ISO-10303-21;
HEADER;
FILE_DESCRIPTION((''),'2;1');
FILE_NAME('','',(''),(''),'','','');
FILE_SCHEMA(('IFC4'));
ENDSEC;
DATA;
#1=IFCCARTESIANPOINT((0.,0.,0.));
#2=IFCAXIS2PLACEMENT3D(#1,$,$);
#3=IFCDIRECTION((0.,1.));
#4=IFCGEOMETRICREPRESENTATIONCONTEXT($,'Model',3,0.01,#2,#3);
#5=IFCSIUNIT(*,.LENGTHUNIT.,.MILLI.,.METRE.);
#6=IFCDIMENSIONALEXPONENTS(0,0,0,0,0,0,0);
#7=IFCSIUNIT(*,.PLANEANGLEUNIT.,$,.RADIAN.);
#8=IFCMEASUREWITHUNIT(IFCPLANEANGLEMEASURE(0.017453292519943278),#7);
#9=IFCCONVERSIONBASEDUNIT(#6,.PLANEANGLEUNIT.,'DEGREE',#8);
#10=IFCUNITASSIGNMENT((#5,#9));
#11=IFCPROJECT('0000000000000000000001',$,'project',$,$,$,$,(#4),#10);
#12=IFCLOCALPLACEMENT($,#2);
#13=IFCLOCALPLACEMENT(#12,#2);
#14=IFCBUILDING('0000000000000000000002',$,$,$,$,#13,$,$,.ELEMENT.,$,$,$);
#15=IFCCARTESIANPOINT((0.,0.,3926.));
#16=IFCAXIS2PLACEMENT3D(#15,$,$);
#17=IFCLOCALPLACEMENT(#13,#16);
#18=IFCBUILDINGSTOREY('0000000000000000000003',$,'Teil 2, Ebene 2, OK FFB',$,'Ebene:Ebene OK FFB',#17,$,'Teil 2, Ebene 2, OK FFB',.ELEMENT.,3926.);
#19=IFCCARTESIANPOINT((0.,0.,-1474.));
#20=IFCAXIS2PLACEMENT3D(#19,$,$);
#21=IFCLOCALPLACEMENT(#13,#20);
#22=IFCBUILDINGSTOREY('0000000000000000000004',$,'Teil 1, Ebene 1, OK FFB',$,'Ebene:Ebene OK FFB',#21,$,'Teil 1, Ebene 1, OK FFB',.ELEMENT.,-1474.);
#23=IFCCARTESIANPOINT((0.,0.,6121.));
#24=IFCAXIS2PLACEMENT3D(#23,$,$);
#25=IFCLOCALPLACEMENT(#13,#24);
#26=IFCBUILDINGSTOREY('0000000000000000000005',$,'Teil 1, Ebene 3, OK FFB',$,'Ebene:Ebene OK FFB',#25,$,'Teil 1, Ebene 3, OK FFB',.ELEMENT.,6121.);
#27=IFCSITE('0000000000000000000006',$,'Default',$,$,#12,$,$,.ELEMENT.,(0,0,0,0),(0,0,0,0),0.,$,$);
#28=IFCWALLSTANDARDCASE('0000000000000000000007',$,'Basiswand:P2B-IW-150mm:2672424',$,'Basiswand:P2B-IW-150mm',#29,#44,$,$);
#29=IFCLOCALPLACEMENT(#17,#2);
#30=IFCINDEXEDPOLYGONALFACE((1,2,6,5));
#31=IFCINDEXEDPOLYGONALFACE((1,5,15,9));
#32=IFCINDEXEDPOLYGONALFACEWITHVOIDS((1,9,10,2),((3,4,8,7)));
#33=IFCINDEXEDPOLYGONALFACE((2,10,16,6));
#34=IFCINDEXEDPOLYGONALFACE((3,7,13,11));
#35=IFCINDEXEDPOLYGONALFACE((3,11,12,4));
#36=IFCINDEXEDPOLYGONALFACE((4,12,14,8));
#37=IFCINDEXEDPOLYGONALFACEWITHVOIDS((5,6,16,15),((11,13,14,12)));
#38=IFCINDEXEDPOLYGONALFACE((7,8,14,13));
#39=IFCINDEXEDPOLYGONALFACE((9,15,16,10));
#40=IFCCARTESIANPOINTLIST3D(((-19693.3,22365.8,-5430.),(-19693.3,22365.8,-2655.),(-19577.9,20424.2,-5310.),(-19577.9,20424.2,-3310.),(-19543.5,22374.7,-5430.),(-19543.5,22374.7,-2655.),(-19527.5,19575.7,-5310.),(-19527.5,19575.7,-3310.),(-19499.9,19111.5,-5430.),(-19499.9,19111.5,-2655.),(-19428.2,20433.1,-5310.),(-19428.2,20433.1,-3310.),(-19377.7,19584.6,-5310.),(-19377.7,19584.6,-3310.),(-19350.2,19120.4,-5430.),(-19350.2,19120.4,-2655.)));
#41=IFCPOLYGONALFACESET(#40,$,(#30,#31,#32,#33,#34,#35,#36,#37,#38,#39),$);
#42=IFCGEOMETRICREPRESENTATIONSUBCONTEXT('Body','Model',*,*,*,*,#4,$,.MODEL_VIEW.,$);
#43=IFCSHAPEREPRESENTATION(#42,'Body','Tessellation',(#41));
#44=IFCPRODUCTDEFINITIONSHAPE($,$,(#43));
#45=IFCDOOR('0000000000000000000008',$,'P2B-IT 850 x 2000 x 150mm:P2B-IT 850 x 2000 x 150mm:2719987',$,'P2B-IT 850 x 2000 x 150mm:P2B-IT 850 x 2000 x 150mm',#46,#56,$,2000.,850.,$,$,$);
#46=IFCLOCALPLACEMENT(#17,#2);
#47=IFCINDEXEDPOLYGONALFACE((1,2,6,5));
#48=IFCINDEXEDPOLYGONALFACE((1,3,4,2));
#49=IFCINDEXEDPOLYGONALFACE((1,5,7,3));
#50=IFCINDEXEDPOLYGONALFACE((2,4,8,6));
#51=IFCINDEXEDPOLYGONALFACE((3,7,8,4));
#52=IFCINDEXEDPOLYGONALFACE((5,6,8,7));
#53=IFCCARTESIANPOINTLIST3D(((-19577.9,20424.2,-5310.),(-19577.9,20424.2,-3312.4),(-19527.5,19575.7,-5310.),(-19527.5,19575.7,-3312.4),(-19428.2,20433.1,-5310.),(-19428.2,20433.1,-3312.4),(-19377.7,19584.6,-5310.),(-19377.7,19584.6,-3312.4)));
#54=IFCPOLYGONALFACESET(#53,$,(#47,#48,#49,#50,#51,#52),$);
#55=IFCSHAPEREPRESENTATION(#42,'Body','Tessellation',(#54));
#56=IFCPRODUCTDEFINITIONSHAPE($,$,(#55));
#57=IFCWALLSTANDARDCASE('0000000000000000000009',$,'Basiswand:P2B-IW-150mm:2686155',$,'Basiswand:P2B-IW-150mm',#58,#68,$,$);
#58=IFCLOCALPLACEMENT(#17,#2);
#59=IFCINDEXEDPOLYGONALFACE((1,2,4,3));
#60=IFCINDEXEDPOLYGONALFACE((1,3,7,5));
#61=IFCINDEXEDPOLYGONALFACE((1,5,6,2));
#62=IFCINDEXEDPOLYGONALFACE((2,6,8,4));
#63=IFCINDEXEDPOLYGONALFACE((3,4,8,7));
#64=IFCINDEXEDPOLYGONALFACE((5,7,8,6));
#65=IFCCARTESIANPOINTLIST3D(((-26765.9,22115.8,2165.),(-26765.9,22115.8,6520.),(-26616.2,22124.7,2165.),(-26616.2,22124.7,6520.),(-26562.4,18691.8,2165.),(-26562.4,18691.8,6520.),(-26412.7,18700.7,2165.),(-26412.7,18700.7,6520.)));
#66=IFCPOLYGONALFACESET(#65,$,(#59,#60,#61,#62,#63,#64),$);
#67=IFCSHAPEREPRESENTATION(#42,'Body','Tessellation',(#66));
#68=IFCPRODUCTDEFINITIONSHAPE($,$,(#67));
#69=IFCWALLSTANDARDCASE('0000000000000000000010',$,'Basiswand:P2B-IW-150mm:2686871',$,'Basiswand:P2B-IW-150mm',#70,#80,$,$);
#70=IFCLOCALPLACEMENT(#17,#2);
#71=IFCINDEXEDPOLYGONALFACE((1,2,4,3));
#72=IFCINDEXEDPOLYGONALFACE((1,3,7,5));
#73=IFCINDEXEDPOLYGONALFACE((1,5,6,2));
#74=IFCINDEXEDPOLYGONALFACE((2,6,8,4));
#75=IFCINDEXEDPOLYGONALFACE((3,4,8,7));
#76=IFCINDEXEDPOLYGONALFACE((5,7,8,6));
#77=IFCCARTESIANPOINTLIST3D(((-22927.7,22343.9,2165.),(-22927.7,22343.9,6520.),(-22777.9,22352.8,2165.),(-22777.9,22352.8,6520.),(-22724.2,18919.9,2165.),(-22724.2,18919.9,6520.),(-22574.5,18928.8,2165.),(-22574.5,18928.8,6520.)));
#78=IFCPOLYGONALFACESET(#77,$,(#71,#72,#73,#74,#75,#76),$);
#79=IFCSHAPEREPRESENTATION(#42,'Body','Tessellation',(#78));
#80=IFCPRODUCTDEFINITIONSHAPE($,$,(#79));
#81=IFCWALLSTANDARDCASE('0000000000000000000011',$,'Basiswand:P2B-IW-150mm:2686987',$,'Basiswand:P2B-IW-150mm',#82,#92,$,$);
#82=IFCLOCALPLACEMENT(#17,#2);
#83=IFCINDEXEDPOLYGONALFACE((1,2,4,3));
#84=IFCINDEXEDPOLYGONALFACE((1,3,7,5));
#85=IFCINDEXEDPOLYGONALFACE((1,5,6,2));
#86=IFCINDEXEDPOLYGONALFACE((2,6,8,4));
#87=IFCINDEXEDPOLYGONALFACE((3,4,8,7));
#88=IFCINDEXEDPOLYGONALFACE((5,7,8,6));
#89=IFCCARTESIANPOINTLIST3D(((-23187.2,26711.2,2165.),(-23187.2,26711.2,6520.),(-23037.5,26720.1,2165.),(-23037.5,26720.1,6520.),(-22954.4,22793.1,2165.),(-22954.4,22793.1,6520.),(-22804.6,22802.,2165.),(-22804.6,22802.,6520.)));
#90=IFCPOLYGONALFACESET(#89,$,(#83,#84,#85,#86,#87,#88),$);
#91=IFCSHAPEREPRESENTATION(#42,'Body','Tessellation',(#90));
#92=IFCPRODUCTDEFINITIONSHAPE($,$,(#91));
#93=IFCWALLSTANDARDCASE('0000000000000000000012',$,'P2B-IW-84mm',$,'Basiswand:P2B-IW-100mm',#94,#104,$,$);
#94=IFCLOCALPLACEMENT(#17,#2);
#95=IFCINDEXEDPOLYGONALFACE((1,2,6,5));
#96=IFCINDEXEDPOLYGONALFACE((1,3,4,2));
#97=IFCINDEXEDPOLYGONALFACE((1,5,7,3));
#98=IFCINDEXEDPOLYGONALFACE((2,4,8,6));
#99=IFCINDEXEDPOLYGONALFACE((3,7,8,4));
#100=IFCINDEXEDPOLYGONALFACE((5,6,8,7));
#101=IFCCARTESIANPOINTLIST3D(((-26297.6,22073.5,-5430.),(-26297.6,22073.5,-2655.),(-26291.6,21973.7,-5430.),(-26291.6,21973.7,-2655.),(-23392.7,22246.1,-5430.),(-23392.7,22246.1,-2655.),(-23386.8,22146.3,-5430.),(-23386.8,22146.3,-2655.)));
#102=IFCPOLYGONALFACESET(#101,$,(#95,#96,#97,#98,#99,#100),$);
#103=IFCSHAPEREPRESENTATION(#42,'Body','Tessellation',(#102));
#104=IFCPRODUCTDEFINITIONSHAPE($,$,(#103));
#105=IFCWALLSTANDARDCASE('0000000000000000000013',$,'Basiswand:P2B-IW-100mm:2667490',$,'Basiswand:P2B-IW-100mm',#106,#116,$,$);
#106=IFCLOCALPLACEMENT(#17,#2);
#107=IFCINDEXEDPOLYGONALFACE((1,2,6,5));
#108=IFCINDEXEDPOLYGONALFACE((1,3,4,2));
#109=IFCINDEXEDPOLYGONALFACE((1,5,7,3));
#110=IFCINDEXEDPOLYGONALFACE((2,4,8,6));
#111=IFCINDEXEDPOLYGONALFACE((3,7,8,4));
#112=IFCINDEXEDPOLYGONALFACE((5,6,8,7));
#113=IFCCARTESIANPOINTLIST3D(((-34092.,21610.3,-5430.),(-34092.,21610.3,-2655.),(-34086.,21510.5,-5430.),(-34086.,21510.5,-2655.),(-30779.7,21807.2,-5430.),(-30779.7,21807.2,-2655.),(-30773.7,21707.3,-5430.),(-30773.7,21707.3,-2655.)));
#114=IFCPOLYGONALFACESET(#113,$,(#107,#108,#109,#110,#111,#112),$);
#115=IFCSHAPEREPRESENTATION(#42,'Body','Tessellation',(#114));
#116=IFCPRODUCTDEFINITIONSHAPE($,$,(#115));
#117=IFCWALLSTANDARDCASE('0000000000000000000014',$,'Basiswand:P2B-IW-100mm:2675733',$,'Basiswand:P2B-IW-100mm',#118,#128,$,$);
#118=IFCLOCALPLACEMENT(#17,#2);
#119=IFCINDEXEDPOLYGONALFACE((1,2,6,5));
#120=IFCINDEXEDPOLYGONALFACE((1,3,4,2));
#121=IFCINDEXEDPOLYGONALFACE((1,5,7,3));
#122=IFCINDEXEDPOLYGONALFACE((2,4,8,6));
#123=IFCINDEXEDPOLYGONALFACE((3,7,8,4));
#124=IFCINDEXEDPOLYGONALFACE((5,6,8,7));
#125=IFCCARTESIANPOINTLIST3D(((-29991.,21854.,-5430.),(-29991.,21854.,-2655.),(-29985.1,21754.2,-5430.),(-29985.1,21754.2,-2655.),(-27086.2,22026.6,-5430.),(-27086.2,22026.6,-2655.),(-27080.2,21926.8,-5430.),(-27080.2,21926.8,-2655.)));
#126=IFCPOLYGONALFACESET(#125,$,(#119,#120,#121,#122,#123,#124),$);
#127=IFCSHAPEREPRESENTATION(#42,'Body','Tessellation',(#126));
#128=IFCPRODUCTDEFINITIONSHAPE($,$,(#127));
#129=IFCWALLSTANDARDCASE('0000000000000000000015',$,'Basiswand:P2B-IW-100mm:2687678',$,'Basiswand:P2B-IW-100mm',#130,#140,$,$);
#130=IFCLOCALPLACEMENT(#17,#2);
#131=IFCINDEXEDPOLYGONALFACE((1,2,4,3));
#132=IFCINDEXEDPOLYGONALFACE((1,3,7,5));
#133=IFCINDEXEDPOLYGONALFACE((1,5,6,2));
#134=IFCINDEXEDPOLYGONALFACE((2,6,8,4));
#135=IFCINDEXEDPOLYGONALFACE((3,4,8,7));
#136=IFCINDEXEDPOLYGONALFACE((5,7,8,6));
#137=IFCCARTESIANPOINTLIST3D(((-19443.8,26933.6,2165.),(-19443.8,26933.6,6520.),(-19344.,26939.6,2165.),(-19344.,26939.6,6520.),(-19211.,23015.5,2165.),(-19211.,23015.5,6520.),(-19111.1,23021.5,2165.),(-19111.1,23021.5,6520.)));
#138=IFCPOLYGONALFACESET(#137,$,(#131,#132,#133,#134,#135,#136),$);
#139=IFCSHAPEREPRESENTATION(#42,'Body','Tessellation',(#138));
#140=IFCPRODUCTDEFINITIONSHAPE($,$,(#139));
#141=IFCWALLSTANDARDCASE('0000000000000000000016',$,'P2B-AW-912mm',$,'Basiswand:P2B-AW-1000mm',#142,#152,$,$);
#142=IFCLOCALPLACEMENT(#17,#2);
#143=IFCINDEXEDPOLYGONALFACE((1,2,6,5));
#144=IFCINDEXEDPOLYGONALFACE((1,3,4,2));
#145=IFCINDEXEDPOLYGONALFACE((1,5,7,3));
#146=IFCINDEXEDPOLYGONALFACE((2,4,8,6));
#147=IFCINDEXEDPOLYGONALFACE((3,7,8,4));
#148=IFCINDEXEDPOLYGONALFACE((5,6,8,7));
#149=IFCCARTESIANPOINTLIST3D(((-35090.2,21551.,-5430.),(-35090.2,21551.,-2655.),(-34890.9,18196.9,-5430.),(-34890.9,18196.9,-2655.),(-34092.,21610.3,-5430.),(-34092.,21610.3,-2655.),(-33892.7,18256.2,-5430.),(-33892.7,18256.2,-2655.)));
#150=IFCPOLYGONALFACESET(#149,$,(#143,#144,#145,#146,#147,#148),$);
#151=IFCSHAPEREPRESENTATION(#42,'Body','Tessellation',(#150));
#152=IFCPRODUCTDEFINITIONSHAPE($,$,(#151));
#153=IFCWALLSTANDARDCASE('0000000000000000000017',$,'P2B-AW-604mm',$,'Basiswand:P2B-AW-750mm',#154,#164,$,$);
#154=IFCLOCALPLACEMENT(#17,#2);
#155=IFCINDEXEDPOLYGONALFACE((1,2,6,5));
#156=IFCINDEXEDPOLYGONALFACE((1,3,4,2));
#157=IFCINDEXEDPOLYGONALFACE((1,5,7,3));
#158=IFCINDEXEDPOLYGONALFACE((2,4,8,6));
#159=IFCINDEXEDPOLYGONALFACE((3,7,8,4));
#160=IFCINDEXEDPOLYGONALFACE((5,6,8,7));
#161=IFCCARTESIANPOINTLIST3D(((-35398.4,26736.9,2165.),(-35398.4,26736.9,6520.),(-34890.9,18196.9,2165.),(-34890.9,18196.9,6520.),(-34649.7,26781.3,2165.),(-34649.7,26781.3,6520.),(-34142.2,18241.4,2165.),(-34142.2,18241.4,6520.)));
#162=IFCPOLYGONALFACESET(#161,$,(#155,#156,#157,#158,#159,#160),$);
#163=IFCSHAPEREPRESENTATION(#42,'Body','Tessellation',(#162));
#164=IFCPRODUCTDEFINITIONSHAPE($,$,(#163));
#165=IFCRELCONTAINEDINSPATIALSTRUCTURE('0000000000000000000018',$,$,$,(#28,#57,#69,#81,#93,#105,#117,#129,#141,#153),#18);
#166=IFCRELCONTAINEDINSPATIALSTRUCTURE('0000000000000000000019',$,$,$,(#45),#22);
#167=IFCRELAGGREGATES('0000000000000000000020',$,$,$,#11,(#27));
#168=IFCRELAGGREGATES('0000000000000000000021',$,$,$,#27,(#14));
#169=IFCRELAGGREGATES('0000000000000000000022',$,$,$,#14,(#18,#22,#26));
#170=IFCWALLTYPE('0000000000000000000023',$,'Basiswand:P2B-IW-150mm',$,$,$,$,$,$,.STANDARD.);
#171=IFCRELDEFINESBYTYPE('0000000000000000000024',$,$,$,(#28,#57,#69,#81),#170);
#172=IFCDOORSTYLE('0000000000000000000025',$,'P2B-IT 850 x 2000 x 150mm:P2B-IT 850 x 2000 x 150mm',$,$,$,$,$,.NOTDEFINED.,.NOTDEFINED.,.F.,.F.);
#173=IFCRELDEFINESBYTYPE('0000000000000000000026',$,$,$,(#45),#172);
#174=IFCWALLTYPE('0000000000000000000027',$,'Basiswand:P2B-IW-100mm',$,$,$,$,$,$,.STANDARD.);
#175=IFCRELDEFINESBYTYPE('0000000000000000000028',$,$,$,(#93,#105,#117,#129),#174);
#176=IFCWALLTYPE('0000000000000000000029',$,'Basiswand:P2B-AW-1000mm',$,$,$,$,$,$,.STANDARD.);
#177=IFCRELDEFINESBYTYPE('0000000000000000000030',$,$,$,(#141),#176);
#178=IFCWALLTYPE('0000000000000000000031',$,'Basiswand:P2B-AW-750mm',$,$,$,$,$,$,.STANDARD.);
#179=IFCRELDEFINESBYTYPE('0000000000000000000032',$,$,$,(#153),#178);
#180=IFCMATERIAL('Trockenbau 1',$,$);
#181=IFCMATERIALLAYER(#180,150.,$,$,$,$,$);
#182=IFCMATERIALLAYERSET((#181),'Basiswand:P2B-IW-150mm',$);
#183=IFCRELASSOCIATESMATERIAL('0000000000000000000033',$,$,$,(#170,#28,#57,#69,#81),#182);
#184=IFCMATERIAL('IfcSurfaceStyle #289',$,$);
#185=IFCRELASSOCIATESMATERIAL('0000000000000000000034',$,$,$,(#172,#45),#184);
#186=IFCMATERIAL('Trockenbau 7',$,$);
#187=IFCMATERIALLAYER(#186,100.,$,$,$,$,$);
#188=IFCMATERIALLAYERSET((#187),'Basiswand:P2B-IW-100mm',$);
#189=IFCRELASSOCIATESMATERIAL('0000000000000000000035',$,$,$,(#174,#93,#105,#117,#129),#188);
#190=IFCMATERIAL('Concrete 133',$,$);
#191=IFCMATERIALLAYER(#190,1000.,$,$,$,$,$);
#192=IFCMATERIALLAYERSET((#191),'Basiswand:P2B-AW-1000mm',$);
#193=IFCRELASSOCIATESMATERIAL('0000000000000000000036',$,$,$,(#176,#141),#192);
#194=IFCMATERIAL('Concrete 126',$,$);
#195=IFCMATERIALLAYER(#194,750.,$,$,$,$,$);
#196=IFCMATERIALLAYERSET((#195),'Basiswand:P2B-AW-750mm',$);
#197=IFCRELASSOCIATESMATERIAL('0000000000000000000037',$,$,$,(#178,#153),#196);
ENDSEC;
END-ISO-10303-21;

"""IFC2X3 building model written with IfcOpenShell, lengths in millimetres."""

from ifc_helpers import new_model, entity, si_unit, converted_unit, direction, frame, frame_2d, origin, place, context, subcontext, project, spatial, rectangle, extrude, source, transform, mapped, material, layer, layer_set, layer_usage, type_object, type_shapes, element, fill, save


model = new_model("IFC2X3")

# Units and contexts
model_context = context("Model", 3, precision=0.01, world=origin(), true_north=direction((0.0, 1.0)))
body_context = subcontext(model_context, "Body", "Model", "MODEL_VIEW")
ifc_project = project(units=[si_unit("LENGTHUNIT", "METRE", prefix="MILLI"), converted_unit("PLANEANGLEUNIT", "DEGREE", entity("IfcPlaneAngleMeasure", 0.017453292519943278), si_unit("PLANEANGLEUNIT", "RADIAN"), dimensions=[0, 0, 0, 0, 0, 0, 0])], contexts=[model_context])

# Site, building, storey
site_placement = place(None, origin())
site = spatial("IfcSite", under=ifc_project, at=site_placement, Name="Default", CompositionType="ELEMENT", RefLatitude=(0, 0, 0, 0), RefLongitude=(0, 0, 0, 0), RefElevation=0.0)
building_placement = place(site_placement, origin())
building = spatial("IfcBuilding", under=site, at=building_placement, CompositionType="ELEMENT")
storey_1_placement = place(building_placement, frame((0.0, 0.0, 3926.0)))
storey_1 = spatial("IfcBuildingStorey", under=building, at=storey_1_placement, Name="Teil 2, Ebene 2, OK FFB", ObjectType="Ebene:Ebene OK FFB", LongName="Teil 2, Ebene 2, OK FFB", CompositionType="ELEMENT", Elevation=3926.0)

# Shared definitions
storey_2_placement = place(building_placement, frame((0.0, 0.0, -1474.0)))
storey_2 = spatial("IfcBuildingStorey", under=building, at=storey_2_placement, Name="Teil 1, Ebene 1, OK FFB", ObjectType="Ebene:Ebene OK FFB", LongName="Teil 1, Ebene 1, OK FFB", CompositionType="ELEMENT", Elevation=-1474.0)

# Shared definitions
ifc_material_1 = material(Name="IfcSurfaceStyle #289")

# Shared definitions
ifc_material_2 = material(Name="Trockenbau 1")
ifc_layer_1 = layer(ifc_material_2, 150.0)
ifc_layer_set_1 = layer_set([ifc_layer_1], Name="Basiswand:P2B-IW-150mm")
wall_type_1 = type_object("IfcWallType", Name="Basiswand:P2B-IW-150mm", PredefinedType="STANDARD", material=ifc_layer_set_1)

# Shared definitions
storey_3_placement = place(building_placement, frame((0.0, 0.0, 6121.0)))
storey_3 = spatial("IfcBuildingStorey", under=building, at=storey_3_placement, Name="Teil 1, Ebene 3, OK FFB", ObjectType="Ebene:Ebene OK FFB", LongName="Teil 1, Ebene 3, OK FFB", CompositionType="ELEMENT", Elevation=6121.0)

# Wall, opening, door
ifc_layer_usage_1 = layer_usage(ifc_layer_set_1, "AXIS2", "POSITIVE", -75.0)
wall_1_placement = place(storey_1_placement, frame((-19425.0, 19116.0, -5430.0), z_axis=(0.0, 0.0, 1.0), x_axis=(-0.059319, 0.998239, 0.0)))
wall_1 = element("IfcWallStandardCase", 1, at=wall_1_placement, inside=storey_1, type_object=wall_type_1, material=ifc_layer_usage_1, Name="Basiswand:P2B-IW-150mm:2672424", ObjectType="Basiswand:P2B-IW-150mm", context=body_context, shape_type="SweptSolid", body=[
    extrude(rectangle(XDim=3260.0, YDim=150.0, at=frame_2d((1630.0, 0.0), x_axis=(-1.0, 0.0))), origin(), (0.0, 0.0, 1.0), 2775.0),
])
opening_1_placement = place(wall_1_placement, frame((-20234.6, -18256.9, 30.0), z_axis=(0.0, 0.0, 1.0), x_axis=(-0.059319, -0.998239, 0.0)))
opening_1 = element("IfcOpeningElement", 2, at=opening_1_placement, cuts=wall_1, ObjectType="Opening", context=body_context, shape_type="SweptSolid", body=[
    extrude(rectangle(XDim=2000.0, YDim=850.0, at=frame_2d((0.0, 0.0), x_axis=(1.0, 0.0))), frame((-19402.9, 20008.9, 1090.0), z_axis=(-0.998239, -0.059319, 0.0), x_axis=(0.0, 0.0, -1.0)), (0.0, 0.0, 1.0), 150.0),
])
door_style_1 = type_object("IfcDoorStyle", Name="P2B-IT 850 x 2000 x 150mm:P2B-IT 850 x 2000 x 150mm", ConstructionType="NOTDEFINED", OperationType="NOTDEFINED", ParameterTakesPrecedence=False, Sizeable=False, material=ifc_material_1)
shared_shape_1 = source(origin(), body_context, "Body", "SweptSolid", [
    extrude(rectangle(XDim=150.0, YDim=850.0, at=frame_2d((0.0, 0.0), x_axis=(1.0, 0.0))), frame((425.0, -75.0, 0.0), z_axis=(0.0, 0.0, 1.0), x_axis=(0.0, 1.0, 0.0)), (0.0, 0.0, 1.0), 1997.6),
])
type_shapes(door_style_1, [shared_shape_1])
door_1_placement = place(opening_1_placement, frame((-19527.5, 19575.7, 90.0), z_axis=(0.0, 0.0, 1.0), x_axis=(-0.059319, 0.998239, 0.0)))
door_1 = element("IfcDoor", 3, at=door_1_placement, inside=storey_2, type_object=door_style_1, material=ifc_material_1, Name="P2B-IT 850 x 2000 x 150mm:P2B-IT 850 x 2000 x 150mm:2719987", ObjectType="P2B-IT 850 x 2000 x 150mm:P2B-IT 850 x 2000 x 150mm", OverallHeight=2000.0, OverallWidth=850.0, context=body_context, shape_type="MappedRepresentation", body=[
    mapped(shared_shape_1, transform((0.0, 0.0, 0.0), scale=1.0)),
])
fill(opening_1, door_1)

# Walls
ifc_layer_usage_2 = layer_usage(ifc_layer_set_1, "AXIS2", "NEGATIVE", 75.0)
wall_2_placement = place(storey_1_placement, frame((-26487.6, 18696.3, 2165.0), z_axis=(0.0, 0.0, 1.0), x_axis=(-0.059319, 0.998239, 0.0)))
element("IfcWallStandardCase", 4, at=wall_2_placement, inside=storey_1, type_object=wall_type_1, material=ifc_layer_usage_2, Name="Basiswand:P2B-IW-150mm:2686155", ObjectType="Basiswand:P2B-IW-150mm", context=body_context, shape_type="SweptSolid", body=[
    extrude(rectangle(XDim=3430.0, YDim=150.0, at=frame_2d((1715.0, 0.0), x_axis=(-1.0, 0.0))), origin(), (0.0, 0.0, 1.0), 4355.0),
])
ifc_layer_usage_3 = layer_usage(ifc_layer_set_1, "AXIS2", "NEGATIVE", 75.0)
wall_3_placement = place(storey_1_placement, frame((-22649.3, 18924.4, 2165.0), z_axis=(0.0, 0.0, 1.0), x_axis=(-0.059319, 0.998239, 0.0)))
element("IfcWallStandardCase", 5, at=wall_3_placement, inside=storey_1, type_object=wall_type_1, material=ifc_layer_usage_3, Name="Basiswand:P2B-IW-150mm:2686871", ObjectType="Basiswand:P2B-IW-150mm", context=body_context, shape_type="SweptSolid", body=[
    extrude(rectangle(XDim=3430.0, YDim=150.0, at=frame_2d((1715.0, 0.0), x_axis=(-1.0, 0.0))), origin(), (0.0, 0.0, 1.0), 4355.0),
])
ifc_layer_usage_4 = layer_usage(ifc_layer_set_1, "AXIS2", "NEGATIVE", 75.0)
wall_4_placement = place(storey_1_placement, frame((-22879.5, 22797.5, 2165.0), z_axis=(0.0, 0.0, 1.0), x_axis=(-0.059319, 0.998239, 0.0)))
element("IfcWallStandardCase", 6, at=wall_4_placement, inside=storey_1, type_object=wall_type_1, material=ifc_layer_usage_4, Name="Basiswand:P2B-IW-150mm:2686987", ObjectType="Basiswand:P2B-IW-150mm", context=body_context, shape_type="SweptSolid", body=[
    extrude(rectangle(XDim=3925.0, YDim=150.0, at=frame_2d((1962.5, 0.0), x_axis=(-1.0, 0.0))), origin(), (0.0, 0.0, 1.0), 4355.0),
])
ifc_material_3 = material(Name="Trockenbau 7")
ifc_layer_2 = layer(ifc_material_3, 100.0)
ifc_layer_set_2 = layer_set([ifc_layer_2], Name="Basiswand:P2B-IW-100mm")
ifc_layer_usage_5 = layer_usage(ifc_layer_set_2, "AXIS2", "POSITIVE", -50.0)
wall_type_2 = type_object("IfcWallType", Name="Basiswand:P2B-IW-100mm", PredefinedType="STANDARD", material=ifc_layer_set_2)
wall_5_placement = place(storey_1_placement, frame((-23389.7, 22196.2, -5430.0), z_axis=(0.0, 0.0, 1.0), x_axis=(-0.998239, -0.059319, 0.0)))
element("IfcWallStandardCase", 7, at=wall_5_placement, inside=storey_1, type_object=wall_type_2, material=ifc_layer_usage_5, Name="P2B-IW-84mm", ObjectType="Basiswand:P2B-IW-100mm", context=body_context, shape_type="SweptSolid", body=[
    extrude(rectangle(XDim=2910.0, YDim=100.0, at=frame_2d((1455.0, 0.0), x_axis=(-1.0, 0.0))), origin(), (0.0, 0.0, 1.0), 2775.0),
])
ifc_layer_usage_6 = layer_usage(ifc_layer_set_2, "AXIS2", "POSITIVE", -50.0)
wall_6_placement = place(storey_1_placement, frame((-30776.7, 21757.2, -5430.0), z_axis=(0.0, 0.0, 1.0), x_axis=(-0.998239, -0.059319, 0.0)))
element("IfcWallStandardCase", 8, at=wall_6_placement, inside=storey_1, type_object=wall_type_2, material=ifc_layer_usage_6, Name="Basiswand:P2B-IW-100mm:2667490", ObjectType="Basiswand:P2B-IW-100mm", context=body_context, shape_type="SweptSolid", body=[
    extrude(rectangle(XDim=3318.2, YDim=100.0, at=frame_2d((1659.1, 0.0), x_axis=(-1.0, 0.0))), origin(), (0.0, 0.0, 1.0), 2775.0),
])
ifc_layer_usage_7 = layer_usage(ifc_layer_set_2, "AXIS2", "POSITIVE", -50.0)
wall_7_placement = place(storey_1_placement, frame((-27083.2, 21976.7, -5430.0), z_axis=(0.0, 0.0, 1.0), x_axis=(-0.998239, -0.059319, 0.0)))
element("IfcWallStandardCase", 9, at=wall_7_placement, inside=storey_1, type_object=wall_type_2, material=ifc_layer_usage_7, Name="Basiswand:P2B-IW-100mm:2675733", ObjectType="Basiswand:P2B-IW-100mm", context=body_context, shape_type="SweptSolid", body=[
    extrude(rectangle(XDim=2910.0, YDim=100.0, at=frame_2d((1455.0, 0.0), x_axis=(-1.0, 0.0))), origin(), (0.0, 0.0, 1.0), 2775.0),
])

# Walls
ifc_layer_usage_8 = layer_usage(ifc_layer_set_2, "AXIS2", "NEGATIVE", 50.0)
wall_8_placement = place(storey_1_placement, frame((-19161.0, 23018.5, 2165.0), z_axis=(0.0, 0.0, 1.0), x_axis=(-0.059319, 0.998239, 0.0)))
element("IfcWallStandardCase", 10, at=wall_8_placement, inside=storey_1, type_object=wall_type_2, material=ifc_layer_usage_8, Name="Basiswand:P2B-IW-100mm:2687678", ObjectType="Basiswand:P2B-IW-100mm", context=body_context, shape_type="SweptSolid", body=[
    extrude(rectangle(XDim=3925.0, YDim=100.0, at=frame_2d((1962.5, 0.0), x_axis=(-1.0, 0.0))), origin(), (0.0, 0.0, 1.0), 4355.0),
])
ifc_material_4 = material(Name="Concrete 133")
ifc_layer_3 = layer(ifc_material_4, 1000.0)
ifc_layer_set_3 = layer_set([ifc_layer_3], Name="Basiswand:P2B-AW-1000mm")
ifc_layer_usage_9 = layer_usage(ifc_layer_set_3, "AXIS2", "NEGATIVE", 500.0)
wall_type_3 = type_object("IfcWallType", Name="Basiswand:P2B-AW-1000mm", PredefinedType="STANDARD", material=ifc_layer_set_3)
wall_9_placement = place(storey_1_placement, frame((-34391.8, 18226.6, -5430.0), z_axis=(0.0, 0.0, 1.0), x_axis=(-0.059319, 0.998239, 0.0)))
element("IfcWallStandardCase", 11, at=wall_9_placement, inside=storey_1, type_object=wall_type_3, material=ifc_layer_usage_9, Name="P2B-AW-912mm", ObjectType="Basiswand:P2B-AW-1000mm", context=body_context, shape_type="SweptSolid", body=[
    extrude(rectangle(XDim=3360.0, YDim=1000.0, at=frame_2d((1680.0, 0.0), x_axis=(-1.0, 0.0))), origin(), (0.0, 0.0, 1.0), 2775.0),
])
ifc_material_5 = material(Name="Concrete 126")
ifc_layer_4 = layer(ifc_material_5, 750.0)
ifc_layer_set_4 = layer_set([ifc_layer_4], Name="Basiswand:P2B-AW-750mm")
ifc_layer_usage_10 = layer_usage(ifc_layer_set_4, "AXIS2", "NEGATIVE", 375.0)
wall_type_4 = type_object("IfcWallType", Name="Basiswand:P2B-AW-750mm", PredefinedType="STANDARD", material=ifc_layer_set_4)
wall_10_placement = place(storey_1_placement, frame((-34516.6, 18219.2, 2165.0), z_axis=(0.0, 0.0, 1.0), x_axis=(-0.059319, 0.998239, 0.0)))
element("IfcWallStandardCase", 12, at=wall_10_placement, inside=storey_1, type_object=wall_type_4, material=ifc_layer_usage_10, Name="P2B-AW-604mm", ObjectType="Basiswand:P2B-AW-750mm", context=body_context, shape_type="SweptSolid", body=[
    extrude(rectangle(XDim=8555.0, YDim=750.0, at=frame_2d((4277.5, 0.0), x_axis=(-1.0, 0.0))), origin(), (0.0, 0.0, 1.0), 4355.0),
])

save(model, "model.ifc")
